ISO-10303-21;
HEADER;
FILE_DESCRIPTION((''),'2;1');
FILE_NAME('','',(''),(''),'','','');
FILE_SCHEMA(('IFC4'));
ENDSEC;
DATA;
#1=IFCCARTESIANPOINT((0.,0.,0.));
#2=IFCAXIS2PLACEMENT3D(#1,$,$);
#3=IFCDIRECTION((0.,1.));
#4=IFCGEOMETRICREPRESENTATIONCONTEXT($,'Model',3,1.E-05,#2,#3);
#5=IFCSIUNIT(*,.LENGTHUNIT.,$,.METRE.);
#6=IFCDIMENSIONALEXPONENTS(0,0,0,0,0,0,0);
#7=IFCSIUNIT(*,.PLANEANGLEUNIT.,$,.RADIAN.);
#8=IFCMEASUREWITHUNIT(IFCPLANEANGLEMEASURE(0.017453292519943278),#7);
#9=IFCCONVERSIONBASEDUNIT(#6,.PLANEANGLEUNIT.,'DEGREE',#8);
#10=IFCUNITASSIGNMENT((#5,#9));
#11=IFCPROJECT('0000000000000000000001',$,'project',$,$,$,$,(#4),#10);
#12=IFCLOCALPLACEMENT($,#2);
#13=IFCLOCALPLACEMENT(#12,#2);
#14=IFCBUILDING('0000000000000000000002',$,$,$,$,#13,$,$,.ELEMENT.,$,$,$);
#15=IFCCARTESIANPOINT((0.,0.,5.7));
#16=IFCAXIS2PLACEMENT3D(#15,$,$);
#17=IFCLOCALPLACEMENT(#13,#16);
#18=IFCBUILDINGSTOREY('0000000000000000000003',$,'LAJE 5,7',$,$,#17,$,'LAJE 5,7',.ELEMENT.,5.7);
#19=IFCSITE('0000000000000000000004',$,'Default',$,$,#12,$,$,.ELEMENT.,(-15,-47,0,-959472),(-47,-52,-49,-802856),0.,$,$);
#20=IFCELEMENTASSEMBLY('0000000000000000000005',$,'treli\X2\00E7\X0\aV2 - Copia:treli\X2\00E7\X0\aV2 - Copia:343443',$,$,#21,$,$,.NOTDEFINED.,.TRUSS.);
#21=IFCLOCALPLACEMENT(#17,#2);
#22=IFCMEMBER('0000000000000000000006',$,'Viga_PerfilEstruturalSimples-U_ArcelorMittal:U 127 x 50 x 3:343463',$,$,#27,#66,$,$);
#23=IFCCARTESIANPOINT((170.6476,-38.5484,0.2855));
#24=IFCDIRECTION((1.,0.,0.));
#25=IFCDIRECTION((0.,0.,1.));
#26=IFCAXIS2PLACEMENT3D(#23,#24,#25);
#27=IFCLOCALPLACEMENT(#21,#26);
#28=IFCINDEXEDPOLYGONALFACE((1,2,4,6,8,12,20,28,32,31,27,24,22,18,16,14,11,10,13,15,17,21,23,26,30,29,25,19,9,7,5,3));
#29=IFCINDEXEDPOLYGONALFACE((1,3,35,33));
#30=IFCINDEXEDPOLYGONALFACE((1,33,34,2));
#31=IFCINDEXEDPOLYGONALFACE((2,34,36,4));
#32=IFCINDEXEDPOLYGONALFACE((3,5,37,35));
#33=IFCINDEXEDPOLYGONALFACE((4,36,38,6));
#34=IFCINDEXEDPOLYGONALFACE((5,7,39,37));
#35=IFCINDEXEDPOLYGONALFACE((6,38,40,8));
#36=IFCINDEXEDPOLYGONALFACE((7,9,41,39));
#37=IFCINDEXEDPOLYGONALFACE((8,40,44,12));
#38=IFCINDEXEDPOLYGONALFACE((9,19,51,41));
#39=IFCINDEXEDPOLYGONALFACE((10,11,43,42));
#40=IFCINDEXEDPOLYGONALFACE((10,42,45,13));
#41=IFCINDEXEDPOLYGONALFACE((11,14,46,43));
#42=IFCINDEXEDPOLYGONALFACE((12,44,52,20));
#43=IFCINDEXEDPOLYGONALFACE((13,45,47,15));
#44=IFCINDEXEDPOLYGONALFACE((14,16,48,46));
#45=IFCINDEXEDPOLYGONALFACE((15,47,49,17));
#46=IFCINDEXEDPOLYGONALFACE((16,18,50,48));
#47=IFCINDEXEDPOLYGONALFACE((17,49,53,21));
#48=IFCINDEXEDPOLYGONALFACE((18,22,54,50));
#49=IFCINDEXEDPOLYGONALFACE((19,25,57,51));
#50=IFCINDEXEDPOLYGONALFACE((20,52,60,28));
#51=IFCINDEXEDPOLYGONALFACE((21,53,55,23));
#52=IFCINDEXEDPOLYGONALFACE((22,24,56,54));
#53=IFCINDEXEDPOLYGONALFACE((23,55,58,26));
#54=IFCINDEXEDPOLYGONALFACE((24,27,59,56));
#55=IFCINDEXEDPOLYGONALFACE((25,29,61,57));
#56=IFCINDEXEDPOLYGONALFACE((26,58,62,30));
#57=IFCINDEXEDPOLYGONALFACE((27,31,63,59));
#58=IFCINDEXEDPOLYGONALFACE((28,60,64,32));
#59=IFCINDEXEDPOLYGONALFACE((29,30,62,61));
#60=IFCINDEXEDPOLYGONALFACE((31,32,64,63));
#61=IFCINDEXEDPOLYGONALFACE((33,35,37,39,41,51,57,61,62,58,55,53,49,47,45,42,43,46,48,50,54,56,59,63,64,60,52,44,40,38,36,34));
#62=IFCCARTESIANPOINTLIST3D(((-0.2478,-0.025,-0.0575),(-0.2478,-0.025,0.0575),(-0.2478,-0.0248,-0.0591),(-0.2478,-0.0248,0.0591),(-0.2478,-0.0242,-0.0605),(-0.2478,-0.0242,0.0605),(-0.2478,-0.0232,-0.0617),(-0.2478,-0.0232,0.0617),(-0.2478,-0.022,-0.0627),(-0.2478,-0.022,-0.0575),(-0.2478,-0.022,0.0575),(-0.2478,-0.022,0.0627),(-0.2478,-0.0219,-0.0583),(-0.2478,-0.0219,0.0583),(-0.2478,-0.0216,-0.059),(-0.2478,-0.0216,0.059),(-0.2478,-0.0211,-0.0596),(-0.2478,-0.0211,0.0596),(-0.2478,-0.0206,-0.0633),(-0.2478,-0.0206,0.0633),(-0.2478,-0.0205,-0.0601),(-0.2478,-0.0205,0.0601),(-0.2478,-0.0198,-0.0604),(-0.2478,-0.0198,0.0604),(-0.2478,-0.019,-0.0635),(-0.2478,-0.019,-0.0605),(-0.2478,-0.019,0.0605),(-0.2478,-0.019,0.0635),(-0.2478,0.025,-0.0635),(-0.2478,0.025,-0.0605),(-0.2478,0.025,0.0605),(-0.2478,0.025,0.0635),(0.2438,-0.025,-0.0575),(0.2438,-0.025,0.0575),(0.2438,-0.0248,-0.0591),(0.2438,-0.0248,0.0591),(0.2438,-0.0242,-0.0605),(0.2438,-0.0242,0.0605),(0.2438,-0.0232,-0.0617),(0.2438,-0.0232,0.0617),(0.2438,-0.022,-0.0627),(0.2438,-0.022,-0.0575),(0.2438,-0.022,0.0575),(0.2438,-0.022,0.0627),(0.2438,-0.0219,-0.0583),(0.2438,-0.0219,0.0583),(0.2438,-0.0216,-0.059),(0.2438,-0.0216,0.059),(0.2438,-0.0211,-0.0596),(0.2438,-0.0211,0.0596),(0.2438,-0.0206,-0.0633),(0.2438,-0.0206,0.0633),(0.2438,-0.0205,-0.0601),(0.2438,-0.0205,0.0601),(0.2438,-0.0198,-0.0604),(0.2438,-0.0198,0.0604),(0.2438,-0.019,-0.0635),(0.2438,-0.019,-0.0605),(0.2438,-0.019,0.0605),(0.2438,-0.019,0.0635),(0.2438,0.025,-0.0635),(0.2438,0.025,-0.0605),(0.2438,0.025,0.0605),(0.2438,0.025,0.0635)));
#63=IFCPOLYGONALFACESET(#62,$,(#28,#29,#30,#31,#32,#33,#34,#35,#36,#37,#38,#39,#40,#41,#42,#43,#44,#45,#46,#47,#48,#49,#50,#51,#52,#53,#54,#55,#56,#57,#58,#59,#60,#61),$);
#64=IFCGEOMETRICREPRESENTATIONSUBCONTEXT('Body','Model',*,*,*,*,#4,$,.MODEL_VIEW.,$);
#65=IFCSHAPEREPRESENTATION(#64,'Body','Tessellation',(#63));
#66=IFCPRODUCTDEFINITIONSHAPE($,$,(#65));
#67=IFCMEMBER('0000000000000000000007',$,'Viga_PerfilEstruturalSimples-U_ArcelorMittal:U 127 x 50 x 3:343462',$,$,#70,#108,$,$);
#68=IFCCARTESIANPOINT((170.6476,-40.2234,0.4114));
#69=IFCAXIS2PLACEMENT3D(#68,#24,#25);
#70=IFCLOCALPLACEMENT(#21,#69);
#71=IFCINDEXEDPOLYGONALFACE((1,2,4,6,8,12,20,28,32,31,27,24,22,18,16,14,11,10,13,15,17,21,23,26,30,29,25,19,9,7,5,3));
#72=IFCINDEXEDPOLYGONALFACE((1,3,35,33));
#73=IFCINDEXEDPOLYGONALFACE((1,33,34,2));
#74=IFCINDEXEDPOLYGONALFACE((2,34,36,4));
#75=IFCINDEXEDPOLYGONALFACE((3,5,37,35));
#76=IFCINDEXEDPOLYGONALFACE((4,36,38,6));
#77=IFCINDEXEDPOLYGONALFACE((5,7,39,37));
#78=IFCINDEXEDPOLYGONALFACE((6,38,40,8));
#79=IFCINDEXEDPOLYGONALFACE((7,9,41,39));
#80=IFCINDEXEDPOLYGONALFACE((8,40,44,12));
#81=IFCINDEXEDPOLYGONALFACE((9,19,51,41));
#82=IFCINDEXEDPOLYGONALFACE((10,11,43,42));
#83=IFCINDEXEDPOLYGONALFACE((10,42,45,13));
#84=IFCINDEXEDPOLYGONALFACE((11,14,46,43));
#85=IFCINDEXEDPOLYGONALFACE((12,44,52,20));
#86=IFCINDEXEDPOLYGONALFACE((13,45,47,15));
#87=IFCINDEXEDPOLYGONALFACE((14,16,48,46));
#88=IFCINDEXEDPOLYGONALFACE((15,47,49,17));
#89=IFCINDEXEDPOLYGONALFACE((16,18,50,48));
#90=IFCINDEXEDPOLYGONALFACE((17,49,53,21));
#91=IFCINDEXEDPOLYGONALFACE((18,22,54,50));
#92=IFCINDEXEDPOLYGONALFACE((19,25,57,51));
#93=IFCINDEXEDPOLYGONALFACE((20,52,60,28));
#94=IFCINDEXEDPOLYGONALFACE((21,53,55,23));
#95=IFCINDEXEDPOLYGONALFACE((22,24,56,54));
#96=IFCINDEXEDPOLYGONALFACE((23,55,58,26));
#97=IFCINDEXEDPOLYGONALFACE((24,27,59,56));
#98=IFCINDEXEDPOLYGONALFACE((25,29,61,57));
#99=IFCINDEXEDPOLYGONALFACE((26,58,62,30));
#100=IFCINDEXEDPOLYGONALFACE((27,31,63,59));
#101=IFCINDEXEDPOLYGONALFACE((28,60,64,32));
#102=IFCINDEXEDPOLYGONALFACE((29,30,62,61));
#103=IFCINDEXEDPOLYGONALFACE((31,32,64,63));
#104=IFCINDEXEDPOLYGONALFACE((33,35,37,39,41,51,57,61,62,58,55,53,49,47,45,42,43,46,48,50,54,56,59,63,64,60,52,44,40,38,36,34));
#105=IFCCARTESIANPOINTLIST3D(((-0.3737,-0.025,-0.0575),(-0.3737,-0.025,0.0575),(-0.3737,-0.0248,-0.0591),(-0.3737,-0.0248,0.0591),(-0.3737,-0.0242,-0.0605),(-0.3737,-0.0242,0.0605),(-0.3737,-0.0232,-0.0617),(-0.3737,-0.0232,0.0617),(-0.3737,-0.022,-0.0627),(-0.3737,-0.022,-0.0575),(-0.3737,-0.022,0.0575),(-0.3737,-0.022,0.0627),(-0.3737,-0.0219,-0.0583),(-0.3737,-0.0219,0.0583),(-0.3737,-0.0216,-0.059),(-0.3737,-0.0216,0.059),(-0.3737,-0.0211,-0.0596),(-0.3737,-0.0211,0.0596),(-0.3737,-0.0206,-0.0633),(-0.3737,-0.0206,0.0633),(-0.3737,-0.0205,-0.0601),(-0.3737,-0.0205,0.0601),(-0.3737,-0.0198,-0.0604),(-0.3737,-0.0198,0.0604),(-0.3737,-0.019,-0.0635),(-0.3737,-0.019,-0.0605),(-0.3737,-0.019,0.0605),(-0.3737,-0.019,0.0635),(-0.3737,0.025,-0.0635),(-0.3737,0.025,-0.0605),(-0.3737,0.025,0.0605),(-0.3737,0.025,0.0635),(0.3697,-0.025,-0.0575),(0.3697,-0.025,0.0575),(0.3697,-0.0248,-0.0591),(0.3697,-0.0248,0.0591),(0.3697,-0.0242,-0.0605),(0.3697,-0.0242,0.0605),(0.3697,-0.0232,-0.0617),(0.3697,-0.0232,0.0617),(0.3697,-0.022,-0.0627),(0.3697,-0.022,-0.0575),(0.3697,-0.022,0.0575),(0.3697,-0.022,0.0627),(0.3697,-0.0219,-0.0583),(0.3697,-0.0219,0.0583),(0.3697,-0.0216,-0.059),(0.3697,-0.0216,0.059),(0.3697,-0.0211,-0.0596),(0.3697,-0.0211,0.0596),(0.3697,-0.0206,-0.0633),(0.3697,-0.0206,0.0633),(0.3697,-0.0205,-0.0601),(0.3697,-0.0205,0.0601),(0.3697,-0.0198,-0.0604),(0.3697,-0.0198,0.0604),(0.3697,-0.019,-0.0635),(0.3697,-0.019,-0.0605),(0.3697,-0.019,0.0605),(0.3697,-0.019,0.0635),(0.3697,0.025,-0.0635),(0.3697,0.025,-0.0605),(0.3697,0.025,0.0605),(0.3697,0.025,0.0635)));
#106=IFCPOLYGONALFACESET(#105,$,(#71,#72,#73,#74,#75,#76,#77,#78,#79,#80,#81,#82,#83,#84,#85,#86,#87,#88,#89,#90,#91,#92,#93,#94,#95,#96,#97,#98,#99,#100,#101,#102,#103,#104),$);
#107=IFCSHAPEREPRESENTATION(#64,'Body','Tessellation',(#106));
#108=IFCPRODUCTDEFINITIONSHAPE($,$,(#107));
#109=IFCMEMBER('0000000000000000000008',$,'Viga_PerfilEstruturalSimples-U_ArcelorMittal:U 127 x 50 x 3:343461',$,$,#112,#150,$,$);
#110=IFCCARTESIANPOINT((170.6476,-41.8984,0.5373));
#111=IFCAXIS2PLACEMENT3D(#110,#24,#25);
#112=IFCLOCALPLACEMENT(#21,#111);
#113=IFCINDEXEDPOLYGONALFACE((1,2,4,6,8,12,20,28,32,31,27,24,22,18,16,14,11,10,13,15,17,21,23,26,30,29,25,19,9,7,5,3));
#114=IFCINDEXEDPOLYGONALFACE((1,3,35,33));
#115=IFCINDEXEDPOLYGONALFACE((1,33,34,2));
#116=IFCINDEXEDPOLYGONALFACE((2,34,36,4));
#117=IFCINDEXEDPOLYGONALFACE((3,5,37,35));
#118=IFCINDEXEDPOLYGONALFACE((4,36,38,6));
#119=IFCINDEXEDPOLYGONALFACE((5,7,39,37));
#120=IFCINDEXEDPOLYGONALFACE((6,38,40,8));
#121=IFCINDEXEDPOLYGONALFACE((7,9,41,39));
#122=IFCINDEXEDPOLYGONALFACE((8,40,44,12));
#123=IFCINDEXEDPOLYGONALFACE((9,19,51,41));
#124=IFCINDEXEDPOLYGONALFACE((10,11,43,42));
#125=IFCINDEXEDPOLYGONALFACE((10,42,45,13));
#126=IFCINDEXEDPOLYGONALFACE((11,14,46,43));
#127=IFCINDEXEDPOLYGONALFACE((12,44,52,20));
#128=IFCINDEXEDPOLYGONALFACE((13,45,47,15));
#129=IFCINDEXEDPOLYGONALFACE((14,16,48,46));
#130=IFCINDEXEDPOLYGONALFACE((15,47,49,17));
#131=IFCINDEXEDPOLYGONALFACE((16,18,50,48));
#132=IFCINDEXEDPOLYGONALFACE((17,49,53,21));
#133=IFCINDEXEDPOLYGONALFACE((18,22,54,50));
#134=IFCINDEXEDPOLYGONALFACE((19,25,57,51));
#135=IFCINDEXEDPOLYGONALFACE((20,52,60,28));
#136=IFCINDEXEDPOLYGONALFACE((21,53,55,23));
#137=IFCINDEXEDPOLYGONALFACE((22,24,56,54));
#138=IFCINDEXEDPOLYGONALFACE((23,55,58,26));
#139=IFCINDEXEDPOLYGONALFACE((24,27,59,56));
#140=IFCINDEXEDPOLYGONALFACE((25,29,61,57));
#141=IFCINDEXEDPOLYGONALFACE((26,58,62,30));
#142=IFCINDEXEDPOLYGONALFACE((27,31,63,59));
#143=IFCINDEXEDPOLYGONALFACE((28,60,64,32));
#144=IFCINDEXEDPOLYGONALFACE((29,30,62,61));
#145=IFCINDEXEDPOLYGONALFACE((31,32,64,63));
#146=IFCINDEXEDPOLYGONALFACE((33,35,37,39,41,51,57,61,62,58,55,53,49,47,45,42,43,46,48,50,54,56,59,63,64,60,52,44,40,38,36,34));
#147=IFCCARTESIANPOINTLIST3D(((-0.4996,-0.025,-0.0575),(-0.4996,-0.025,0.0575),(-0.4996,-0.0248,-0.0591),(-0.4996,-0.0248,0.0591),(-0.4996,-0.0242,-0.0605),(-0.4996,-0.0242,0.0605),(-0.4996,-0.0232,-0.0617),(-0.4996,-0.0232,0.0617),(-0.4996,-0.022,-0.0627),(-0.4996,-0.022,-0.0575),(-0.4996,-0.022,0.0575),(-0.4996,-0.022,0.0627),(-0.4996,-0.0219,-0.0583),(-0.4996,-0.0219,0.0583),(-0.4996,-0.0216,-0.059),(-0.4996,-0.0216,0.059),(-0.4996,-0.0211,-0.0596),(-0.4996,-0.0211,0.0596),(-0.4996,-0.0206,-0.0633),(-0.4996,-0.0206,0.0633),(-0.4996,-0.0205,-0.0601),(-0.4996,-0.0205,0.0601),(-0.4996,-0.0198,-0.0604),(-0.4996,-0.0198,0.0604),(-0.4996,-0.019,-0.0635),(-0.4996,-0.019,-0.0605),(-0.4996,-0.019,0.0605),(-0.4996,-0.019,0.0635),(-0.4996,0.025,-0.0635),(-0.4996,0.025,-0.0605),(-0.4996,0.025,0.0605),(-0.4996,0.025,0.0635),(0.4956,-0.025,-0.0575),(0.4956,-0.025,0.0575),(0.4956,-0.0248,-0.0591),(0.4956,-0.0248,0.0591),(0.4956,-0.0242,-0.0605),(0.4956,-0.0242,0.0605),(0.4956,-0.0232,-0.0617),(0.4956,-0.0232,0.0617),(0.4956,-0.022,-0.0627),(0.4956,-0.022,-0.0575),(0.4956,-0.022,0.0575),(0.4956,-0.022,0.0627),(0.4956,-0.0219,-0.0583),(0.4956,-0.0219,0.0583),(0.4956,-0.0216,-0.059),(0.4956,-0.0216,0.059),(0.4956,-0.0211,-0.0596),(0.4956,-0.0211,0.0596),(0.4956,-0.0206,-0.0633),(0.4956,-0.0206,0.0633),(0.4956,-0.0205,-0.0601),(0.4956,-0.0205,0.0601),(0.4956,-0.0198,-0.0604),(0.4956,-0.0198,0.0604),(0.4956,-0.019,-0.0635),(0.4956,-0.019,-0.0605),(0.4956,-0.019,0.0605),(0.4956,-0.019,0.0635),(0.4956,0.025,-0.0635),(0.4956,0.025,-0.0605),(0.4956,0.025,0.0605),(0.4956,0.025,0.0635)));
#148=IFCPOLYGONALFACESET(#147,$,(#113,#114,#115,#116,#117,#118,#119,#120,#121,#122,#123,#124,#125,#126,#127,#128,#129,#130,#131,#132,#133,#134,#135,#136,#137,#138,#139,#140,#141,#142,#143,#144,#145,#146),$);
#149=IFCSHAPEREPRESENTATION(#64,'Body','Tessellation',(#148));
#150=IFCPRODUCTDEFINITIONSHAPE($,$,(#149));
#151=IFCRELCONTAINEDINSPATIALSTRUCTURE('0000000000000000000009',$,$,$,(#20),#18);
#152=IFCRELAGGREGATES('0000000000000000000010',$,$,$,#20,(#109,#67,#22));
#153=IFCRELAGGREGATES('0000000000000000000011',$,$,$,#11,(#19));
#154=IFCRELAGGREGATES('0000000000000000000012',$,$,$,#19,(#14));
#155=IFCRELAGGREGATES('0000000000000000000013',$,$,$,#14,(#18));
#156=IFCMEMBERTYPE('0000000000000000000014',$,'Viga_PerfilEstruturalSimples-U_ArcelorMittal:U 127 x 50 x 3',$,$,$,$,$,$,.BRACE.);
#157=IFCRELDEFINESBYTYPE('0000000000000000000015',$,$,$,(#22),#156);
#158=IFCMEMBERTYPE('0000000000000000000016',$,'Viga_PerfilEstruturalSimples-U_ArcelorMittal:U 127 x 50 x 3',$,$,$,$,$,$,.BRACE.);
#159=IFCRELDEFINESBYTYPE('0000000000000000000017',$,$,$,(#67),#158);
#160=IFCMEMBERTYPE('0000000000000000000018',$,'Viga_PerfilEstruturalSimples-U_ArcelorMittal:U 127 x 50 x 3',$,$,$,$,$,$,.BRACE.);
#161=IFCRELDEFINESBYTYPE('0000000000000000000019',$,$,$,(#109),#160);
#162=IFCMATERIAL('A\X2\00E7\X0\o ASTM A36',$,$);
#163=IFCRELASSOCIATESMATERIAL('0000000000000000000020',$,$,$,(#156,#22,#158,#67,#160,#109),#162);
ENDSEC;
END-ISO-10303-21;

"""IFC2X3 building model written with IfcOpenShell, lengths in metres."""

from ifc_helpers import new_model, entity, si_unit, converted_unit, direction, frame, frame_2d, origin, place, context, subcontext, project, spatial, polyline, circle_curve, parameter, trimmed, segment, composite_curve, outline, extrude, source, transform, mapped, material, type_object, type_shapes, element, aggregate, save


model = new_model("IFC2X3")

# Units and contexts
model_context = context("Model", 3, precision=1e-05, world=origin(), true_north=direction((0.0, 1.0)))
body_context = subcontext(model_context, "Body", "Model", "MODEL_VIEW")
ifc_project = project(units=[si_unit("LENGTHUNIT", "METRE"), converted_unit("PLANEANGLEUNIT", "DEGREE", entity("IfcPlaneAngleMeasure", 0.017453292519943278), si_unit("PLANEANGLEUNIT", "RADIAN"), dimensions=[0, 0, 0, 0, 0, 0, 0])], contexts=[model_context])

# Site, building, storey
site_placement = place(None, origin())
site = spatial("IfcSite", under=ifc_project, at=site_placement, Name="Default", CompositionType="ELEMENT", RefLatitude=(-15, -47, 0, -959472), RefLongitude=(-47, -52, -49, -802856), RefElevation=0.0)
building_placement = place(site_placement, origin())
building = spatial("IfcBuilding", under=site, at=building_placement, CompositionType="ELEMENT")
storey_placement = place(building_placement, frame((0.0, 0.0, 5.7)))
storey = spatial("IfcBuildingStorey", under=building, at=storey_placement, Name="LAJE 5,7", LongName="LAJE 5,7", CompositionType="ELEMENT", Elevation=5.7)

# Shared definitions
ifc_material = material(Name="Aço ASTM A36")

# Element assembly, member
assembly_1_placement = place(storey_placement, origin())
assembly_1 = element("IfcElementAssembly", 1, at=assembly_1_placement, inside=storey, Name="treliçaV2 - Copia:treliçaV2 - Copia:343443", AssemblyPlace="NOTDEFINED", PredefinedType="TRUSS")
member_type_1 = type_object("IfcMemberType", Name="Viga_PerfilEstruturalSimples-U_ArcelorMittal:U 127 x 50 x 3", PredefinedType="BRACE", material=ifc_material)
shared_shape_1 = source(origin(), body_context, "Body", "SweptSolid", [
    extrude(outline(composite_curve([segment(polyline([(-0.0575, -0.0192), (0.0575, -0.0192)]), True, "CONTINUOUS"), segment(trimmed(circle_curve(frame_2d((0.0575, -0.0132), x_axis=(0.0, 1.0)), 0.006), [parameter(180.0)], [parameter(270.0)], True, "PARAMETER"), True, "CONTINUOUS"), segment(polyline([(0.0635, -0.0132), (0.0635, 0.0308)]), True, "CONTINUOUS"), segment(polyline([(0.0635, 0.0308), (0.0605, 0.0308)]), True, "CONTINUOUS"), segment(polyline([(0.0605, 0.0308), (0.0605, -0.0132)]), True, "CONTINUOUS"), segment(trimmed(circle_curve(frame_2d((0.0575, -0.0132), x_axis=(0.0, 1.0)), 0.003), [parameter(180.0)], [parameter(270.0)], True, "PARAMETER"), False, "CONTINUOUS"), segment(polyline([(0.0575, -0.0162), (-0.0575, -0.0162)]), True, "CONTINUOUS"), segment(trimmed(circle_curve(frame_2d((-0.0575, -0.0132), x_axis=(0.0, 1.0)), 0.003), [parameter(90.0)], [parameter(180.0)], True, "PARAMETER"), False, "CONTINUOUS"), segment(polyline([(-0.0605, -0.0132), (-0.0605, 0.0308)]), True, "CONTINUOUS"), segment(polyline([(-0.0605, 0.0308), (-0.0635, 0.0308)]), True, "CONTINUOUS"), segment(polyline([(-0.0635, 0.0308), (-0.0635, -0.0132)]), True, "CONTINUOUS"), segment(trimmed(circle_curve(frame_2d((-0.0575, -0.0132), x_axis=(0.0, 1.0)), 0.006), [parameter(90.0)], [parameter(180.0)], True, "PARAMETER"), True, "CONTINUOUS")], self_intersect=False)), frame((-0.2478, -0.0058, 0.0), z_axis=(1.0, 0.0, 0.0), x_axis=(0.0, 0.0, -1.0)), (0.0, 0.0, 1.0), 0.4916),
])
type_shapes(member_type_1, [shared_shape_1])
member_1_placement = place(assembly_1_placement, frame((170.6476, -38.5484, 0.2855), z_axis=(1.0, 0.0, 0.0), x_axis=(0.0, 0.0, 1.0)))
member_1 = element("IfcMember", 2, at=member_1_placement, type_object=member_type_1, material=ifc_material, Name="Viga_PerfilEstruturalSimples-U_ArcelorMittal:U 127 x 50 x 3:343463", context=body_context, shape_type="MappedRepresentation", body=[
    mapped(shared_shape_1, transform((0.0, 0.0, 0.0), scale=1.0)),
])

# Members
member_type_2 = type_object("IfcMemberType", Name="Viga_PerfilEstruturalSimples-U_ArcelorMittal:U 127 x 50 x 3", PredefinedType="BRACE", material=ifc_material)
shared_shape_2 = source(origin(), body_context, "Body", "SweptSolid", [
    extrude(outline(composite_curve([segment(polyline([(-0.0575, -0.0192), (0.0575, -0.0192)]), True, "CONTINUOUS"), segment(trimmed(circle_curve(frame_2d((0.0575, -0.0132), x_axis=(0.0, 1.0)), 0.006), [parameter(180.0)], [parameter(270.0)], True, "PARAMETER"), True, "CONTINUOUS"), segment(polyline([(0.0635, -0.0132), (0.0635, 0.0308)]), True, "CONTINUOUS"), segment(polyline([(0.0635, 0.0308), (0.0605, 0.0308)]), True, "CONTINUOUS"), segment(polyline([(0.0605, 0.0308), (0.0605, -0.0132)]), True, "CONTINUOUS"), segment(trimmed(circle_curve(frame_2d((0.0575, -0.0132), x_axis=(0.0, 1.0)), 0.003), [parameter(180.0)], [parameter(270.0)], True, "PARAMETER"), False, "CONTINUOUS"), segment(polyline([(0.0575, -0.0162), (-0.0575, -0.0162)]), True, "CONTINUOUS"), segment(trimmed(circle_curve(frame_2d((-0.0575, -0.0132), x_axis=(0.0, 1.0)), 0.003), [parameter(90.0)], [parameter(180.0)], True, "PARAMETER"), False, "CONTINUOUS"), segment(polyline([(-0.0605, -0.0132), (-0.0605, 0.0308)]), True, "CONTINUOUS"), segment(polyline([(-0.0605, 0.0308), (-0.0635, 0.0308)]), True, "CONTINUOUS"), segment(polyline([(-0.0635, 0.0308), (-0.0635, -0.0132)]), True, "CONTINUOUS"), segment(trimmed(circle_curve(frame_2d((-0.0575, -0.0132), x_axis=(0.0, 1.0)), 0.006), [parameter(90.0)], [parameter(180.0)], True, "PARAMETER"), True, "CONTINUOUS")], self_intersect=False)), frame((-0.3737, -0.0058, 0.0), z_axis=(1.0, 0.0, 0.0), x_axis=(0.0, 0.0, -1.0)), (0.0, 0.0, 1.0), 0.7434),
])
type_shapes(member_type_2, [shared_shape_2])
member_2_placement = place(assembly_1_placement, frame((170.6476, -40.2234, 0.4114), z_axis=(1.0, 0.0, 0.0), x_axis=(0.0, 0.0, 1.0)))
member_2 = element("IfcMember", 3, at=member_2_placement, type_object=member_type_2, material=ifc_material, Name="Viga_PerfilEstruturalSimples-U_ArcelorMittal:U 127 x 50 x 3:343462", context=body_context, shape_type="MappedRepresentation", body=[
    mapped(shared_shape_2, transform((0.0, 0.0, 0.0), scale=1.0)),
])
member_type_3 = type_object("IfcMemberType", Name="Viga_PerfilEstruturalSimples-U_ArcelorMittal:U 127 x 50 x 3", PredefinedType="BRACE", material=ifc_material)
shared_shape_3 = source(origin(), body_context, "Body", "SweptSolid", [
    extrude(outline(composite_curve([segment(polyline([(-0.0575, -0.0192), (0.0575, -0.0192)]), True, "CONTINUOUS"), segment(trimmed(circle_curve(frame_2d((0.0575, -0.0132), x_axis=(0.0, 1.0)), 0.006), [parameter(180.0)], [parameter(270.0)], True, "PARAMETER"), True, "CONTINUOUS"), segment(polyline([(0.0635, -0.0132), (0.0635, 0.0308)]), True, "CONTINUOUS"), segment(polyline([(0.0635, 0.0308), (0.0605, 0.0308)]), True, "CONTINUOUS"), segment(polyline([(0.0605, 0.0308), (0.0605, -0.0132)]), True, "CONTINUOUS"), segment(trimmed(circle_curve(frame_2d((0.0575, -0.0132), x_axis=(0.0, 1.0)), 0.003), [parameter(180.0)], [parameter(270.0)], True, "PARAMETER"), False, "CONTINUOUS"), segment(polyline([(0.0575, -0.0162), (-0.0575, -0.0162)]), True, "CONTINUOUS"), segment(trimmed(circle_curve(frame_2d((-0.0575, -0.0132), x_axis=(0.0, 1.0)), 0.003), [parameter(90.0)], [parameter(180.0)], True, "PARAMETER"), False, "CONTINUOUS"), segment(polyline([(-0.0605, -0.0132), (-0.0605, 0.0308)]), True, "CONTINUOUS"), segment(polyline([(-0.0605, 0.0308), (-0.0635, 0.0308)]), True, "CONTINUOUS"), segment(polyline([(-0.0635, 0.0308), (-0.0635, -0.0132)]), True, "CONTINUOUS"), segment(trimmed(circle_curve(frame_2d((-0.0575, -0.0132), x_axis=(0.0, 1.0)), 0.006), [parameter(90.0)], [parameter(180.0)], True, "PARAMETER"), True, "CONTINUOUS")], self_intersect=False)), frame((-0.4996, -0.0058, 0.0), z_axis=(1.0, 0.0, 0.0), x_axis=(0.0, 0.0, -1.0)), (0.0, 0.0, 1.0), 0.9952),
])
type_shapes(member_type_3, [shared_shape_3])
member_3_placement = place(assembly_1_placement, frame((170.6476, -41.8984, 0.5373), z_axis=(1.0, 0.0, 0.0), x_axis=(0.0, 0.0, 1.0)))
member_3 = element("IfcMember", 4, at=member_3_placement, type_object=member_type_3, material=ifc_material, Name="Viga_PerfilEstruturalSimples-U_ArcelorMittal:U 127 x 50 x 3:343461", context=body_context, shape_type="MappedRepresentation", body=[
    mapped(shared_shape_3, transform((0.0, 0.0, 0.0), scale=1.0)),
])
aggregate(assembly_1, [member_3, member_2, member_1])

save(model, "model.ifc")
